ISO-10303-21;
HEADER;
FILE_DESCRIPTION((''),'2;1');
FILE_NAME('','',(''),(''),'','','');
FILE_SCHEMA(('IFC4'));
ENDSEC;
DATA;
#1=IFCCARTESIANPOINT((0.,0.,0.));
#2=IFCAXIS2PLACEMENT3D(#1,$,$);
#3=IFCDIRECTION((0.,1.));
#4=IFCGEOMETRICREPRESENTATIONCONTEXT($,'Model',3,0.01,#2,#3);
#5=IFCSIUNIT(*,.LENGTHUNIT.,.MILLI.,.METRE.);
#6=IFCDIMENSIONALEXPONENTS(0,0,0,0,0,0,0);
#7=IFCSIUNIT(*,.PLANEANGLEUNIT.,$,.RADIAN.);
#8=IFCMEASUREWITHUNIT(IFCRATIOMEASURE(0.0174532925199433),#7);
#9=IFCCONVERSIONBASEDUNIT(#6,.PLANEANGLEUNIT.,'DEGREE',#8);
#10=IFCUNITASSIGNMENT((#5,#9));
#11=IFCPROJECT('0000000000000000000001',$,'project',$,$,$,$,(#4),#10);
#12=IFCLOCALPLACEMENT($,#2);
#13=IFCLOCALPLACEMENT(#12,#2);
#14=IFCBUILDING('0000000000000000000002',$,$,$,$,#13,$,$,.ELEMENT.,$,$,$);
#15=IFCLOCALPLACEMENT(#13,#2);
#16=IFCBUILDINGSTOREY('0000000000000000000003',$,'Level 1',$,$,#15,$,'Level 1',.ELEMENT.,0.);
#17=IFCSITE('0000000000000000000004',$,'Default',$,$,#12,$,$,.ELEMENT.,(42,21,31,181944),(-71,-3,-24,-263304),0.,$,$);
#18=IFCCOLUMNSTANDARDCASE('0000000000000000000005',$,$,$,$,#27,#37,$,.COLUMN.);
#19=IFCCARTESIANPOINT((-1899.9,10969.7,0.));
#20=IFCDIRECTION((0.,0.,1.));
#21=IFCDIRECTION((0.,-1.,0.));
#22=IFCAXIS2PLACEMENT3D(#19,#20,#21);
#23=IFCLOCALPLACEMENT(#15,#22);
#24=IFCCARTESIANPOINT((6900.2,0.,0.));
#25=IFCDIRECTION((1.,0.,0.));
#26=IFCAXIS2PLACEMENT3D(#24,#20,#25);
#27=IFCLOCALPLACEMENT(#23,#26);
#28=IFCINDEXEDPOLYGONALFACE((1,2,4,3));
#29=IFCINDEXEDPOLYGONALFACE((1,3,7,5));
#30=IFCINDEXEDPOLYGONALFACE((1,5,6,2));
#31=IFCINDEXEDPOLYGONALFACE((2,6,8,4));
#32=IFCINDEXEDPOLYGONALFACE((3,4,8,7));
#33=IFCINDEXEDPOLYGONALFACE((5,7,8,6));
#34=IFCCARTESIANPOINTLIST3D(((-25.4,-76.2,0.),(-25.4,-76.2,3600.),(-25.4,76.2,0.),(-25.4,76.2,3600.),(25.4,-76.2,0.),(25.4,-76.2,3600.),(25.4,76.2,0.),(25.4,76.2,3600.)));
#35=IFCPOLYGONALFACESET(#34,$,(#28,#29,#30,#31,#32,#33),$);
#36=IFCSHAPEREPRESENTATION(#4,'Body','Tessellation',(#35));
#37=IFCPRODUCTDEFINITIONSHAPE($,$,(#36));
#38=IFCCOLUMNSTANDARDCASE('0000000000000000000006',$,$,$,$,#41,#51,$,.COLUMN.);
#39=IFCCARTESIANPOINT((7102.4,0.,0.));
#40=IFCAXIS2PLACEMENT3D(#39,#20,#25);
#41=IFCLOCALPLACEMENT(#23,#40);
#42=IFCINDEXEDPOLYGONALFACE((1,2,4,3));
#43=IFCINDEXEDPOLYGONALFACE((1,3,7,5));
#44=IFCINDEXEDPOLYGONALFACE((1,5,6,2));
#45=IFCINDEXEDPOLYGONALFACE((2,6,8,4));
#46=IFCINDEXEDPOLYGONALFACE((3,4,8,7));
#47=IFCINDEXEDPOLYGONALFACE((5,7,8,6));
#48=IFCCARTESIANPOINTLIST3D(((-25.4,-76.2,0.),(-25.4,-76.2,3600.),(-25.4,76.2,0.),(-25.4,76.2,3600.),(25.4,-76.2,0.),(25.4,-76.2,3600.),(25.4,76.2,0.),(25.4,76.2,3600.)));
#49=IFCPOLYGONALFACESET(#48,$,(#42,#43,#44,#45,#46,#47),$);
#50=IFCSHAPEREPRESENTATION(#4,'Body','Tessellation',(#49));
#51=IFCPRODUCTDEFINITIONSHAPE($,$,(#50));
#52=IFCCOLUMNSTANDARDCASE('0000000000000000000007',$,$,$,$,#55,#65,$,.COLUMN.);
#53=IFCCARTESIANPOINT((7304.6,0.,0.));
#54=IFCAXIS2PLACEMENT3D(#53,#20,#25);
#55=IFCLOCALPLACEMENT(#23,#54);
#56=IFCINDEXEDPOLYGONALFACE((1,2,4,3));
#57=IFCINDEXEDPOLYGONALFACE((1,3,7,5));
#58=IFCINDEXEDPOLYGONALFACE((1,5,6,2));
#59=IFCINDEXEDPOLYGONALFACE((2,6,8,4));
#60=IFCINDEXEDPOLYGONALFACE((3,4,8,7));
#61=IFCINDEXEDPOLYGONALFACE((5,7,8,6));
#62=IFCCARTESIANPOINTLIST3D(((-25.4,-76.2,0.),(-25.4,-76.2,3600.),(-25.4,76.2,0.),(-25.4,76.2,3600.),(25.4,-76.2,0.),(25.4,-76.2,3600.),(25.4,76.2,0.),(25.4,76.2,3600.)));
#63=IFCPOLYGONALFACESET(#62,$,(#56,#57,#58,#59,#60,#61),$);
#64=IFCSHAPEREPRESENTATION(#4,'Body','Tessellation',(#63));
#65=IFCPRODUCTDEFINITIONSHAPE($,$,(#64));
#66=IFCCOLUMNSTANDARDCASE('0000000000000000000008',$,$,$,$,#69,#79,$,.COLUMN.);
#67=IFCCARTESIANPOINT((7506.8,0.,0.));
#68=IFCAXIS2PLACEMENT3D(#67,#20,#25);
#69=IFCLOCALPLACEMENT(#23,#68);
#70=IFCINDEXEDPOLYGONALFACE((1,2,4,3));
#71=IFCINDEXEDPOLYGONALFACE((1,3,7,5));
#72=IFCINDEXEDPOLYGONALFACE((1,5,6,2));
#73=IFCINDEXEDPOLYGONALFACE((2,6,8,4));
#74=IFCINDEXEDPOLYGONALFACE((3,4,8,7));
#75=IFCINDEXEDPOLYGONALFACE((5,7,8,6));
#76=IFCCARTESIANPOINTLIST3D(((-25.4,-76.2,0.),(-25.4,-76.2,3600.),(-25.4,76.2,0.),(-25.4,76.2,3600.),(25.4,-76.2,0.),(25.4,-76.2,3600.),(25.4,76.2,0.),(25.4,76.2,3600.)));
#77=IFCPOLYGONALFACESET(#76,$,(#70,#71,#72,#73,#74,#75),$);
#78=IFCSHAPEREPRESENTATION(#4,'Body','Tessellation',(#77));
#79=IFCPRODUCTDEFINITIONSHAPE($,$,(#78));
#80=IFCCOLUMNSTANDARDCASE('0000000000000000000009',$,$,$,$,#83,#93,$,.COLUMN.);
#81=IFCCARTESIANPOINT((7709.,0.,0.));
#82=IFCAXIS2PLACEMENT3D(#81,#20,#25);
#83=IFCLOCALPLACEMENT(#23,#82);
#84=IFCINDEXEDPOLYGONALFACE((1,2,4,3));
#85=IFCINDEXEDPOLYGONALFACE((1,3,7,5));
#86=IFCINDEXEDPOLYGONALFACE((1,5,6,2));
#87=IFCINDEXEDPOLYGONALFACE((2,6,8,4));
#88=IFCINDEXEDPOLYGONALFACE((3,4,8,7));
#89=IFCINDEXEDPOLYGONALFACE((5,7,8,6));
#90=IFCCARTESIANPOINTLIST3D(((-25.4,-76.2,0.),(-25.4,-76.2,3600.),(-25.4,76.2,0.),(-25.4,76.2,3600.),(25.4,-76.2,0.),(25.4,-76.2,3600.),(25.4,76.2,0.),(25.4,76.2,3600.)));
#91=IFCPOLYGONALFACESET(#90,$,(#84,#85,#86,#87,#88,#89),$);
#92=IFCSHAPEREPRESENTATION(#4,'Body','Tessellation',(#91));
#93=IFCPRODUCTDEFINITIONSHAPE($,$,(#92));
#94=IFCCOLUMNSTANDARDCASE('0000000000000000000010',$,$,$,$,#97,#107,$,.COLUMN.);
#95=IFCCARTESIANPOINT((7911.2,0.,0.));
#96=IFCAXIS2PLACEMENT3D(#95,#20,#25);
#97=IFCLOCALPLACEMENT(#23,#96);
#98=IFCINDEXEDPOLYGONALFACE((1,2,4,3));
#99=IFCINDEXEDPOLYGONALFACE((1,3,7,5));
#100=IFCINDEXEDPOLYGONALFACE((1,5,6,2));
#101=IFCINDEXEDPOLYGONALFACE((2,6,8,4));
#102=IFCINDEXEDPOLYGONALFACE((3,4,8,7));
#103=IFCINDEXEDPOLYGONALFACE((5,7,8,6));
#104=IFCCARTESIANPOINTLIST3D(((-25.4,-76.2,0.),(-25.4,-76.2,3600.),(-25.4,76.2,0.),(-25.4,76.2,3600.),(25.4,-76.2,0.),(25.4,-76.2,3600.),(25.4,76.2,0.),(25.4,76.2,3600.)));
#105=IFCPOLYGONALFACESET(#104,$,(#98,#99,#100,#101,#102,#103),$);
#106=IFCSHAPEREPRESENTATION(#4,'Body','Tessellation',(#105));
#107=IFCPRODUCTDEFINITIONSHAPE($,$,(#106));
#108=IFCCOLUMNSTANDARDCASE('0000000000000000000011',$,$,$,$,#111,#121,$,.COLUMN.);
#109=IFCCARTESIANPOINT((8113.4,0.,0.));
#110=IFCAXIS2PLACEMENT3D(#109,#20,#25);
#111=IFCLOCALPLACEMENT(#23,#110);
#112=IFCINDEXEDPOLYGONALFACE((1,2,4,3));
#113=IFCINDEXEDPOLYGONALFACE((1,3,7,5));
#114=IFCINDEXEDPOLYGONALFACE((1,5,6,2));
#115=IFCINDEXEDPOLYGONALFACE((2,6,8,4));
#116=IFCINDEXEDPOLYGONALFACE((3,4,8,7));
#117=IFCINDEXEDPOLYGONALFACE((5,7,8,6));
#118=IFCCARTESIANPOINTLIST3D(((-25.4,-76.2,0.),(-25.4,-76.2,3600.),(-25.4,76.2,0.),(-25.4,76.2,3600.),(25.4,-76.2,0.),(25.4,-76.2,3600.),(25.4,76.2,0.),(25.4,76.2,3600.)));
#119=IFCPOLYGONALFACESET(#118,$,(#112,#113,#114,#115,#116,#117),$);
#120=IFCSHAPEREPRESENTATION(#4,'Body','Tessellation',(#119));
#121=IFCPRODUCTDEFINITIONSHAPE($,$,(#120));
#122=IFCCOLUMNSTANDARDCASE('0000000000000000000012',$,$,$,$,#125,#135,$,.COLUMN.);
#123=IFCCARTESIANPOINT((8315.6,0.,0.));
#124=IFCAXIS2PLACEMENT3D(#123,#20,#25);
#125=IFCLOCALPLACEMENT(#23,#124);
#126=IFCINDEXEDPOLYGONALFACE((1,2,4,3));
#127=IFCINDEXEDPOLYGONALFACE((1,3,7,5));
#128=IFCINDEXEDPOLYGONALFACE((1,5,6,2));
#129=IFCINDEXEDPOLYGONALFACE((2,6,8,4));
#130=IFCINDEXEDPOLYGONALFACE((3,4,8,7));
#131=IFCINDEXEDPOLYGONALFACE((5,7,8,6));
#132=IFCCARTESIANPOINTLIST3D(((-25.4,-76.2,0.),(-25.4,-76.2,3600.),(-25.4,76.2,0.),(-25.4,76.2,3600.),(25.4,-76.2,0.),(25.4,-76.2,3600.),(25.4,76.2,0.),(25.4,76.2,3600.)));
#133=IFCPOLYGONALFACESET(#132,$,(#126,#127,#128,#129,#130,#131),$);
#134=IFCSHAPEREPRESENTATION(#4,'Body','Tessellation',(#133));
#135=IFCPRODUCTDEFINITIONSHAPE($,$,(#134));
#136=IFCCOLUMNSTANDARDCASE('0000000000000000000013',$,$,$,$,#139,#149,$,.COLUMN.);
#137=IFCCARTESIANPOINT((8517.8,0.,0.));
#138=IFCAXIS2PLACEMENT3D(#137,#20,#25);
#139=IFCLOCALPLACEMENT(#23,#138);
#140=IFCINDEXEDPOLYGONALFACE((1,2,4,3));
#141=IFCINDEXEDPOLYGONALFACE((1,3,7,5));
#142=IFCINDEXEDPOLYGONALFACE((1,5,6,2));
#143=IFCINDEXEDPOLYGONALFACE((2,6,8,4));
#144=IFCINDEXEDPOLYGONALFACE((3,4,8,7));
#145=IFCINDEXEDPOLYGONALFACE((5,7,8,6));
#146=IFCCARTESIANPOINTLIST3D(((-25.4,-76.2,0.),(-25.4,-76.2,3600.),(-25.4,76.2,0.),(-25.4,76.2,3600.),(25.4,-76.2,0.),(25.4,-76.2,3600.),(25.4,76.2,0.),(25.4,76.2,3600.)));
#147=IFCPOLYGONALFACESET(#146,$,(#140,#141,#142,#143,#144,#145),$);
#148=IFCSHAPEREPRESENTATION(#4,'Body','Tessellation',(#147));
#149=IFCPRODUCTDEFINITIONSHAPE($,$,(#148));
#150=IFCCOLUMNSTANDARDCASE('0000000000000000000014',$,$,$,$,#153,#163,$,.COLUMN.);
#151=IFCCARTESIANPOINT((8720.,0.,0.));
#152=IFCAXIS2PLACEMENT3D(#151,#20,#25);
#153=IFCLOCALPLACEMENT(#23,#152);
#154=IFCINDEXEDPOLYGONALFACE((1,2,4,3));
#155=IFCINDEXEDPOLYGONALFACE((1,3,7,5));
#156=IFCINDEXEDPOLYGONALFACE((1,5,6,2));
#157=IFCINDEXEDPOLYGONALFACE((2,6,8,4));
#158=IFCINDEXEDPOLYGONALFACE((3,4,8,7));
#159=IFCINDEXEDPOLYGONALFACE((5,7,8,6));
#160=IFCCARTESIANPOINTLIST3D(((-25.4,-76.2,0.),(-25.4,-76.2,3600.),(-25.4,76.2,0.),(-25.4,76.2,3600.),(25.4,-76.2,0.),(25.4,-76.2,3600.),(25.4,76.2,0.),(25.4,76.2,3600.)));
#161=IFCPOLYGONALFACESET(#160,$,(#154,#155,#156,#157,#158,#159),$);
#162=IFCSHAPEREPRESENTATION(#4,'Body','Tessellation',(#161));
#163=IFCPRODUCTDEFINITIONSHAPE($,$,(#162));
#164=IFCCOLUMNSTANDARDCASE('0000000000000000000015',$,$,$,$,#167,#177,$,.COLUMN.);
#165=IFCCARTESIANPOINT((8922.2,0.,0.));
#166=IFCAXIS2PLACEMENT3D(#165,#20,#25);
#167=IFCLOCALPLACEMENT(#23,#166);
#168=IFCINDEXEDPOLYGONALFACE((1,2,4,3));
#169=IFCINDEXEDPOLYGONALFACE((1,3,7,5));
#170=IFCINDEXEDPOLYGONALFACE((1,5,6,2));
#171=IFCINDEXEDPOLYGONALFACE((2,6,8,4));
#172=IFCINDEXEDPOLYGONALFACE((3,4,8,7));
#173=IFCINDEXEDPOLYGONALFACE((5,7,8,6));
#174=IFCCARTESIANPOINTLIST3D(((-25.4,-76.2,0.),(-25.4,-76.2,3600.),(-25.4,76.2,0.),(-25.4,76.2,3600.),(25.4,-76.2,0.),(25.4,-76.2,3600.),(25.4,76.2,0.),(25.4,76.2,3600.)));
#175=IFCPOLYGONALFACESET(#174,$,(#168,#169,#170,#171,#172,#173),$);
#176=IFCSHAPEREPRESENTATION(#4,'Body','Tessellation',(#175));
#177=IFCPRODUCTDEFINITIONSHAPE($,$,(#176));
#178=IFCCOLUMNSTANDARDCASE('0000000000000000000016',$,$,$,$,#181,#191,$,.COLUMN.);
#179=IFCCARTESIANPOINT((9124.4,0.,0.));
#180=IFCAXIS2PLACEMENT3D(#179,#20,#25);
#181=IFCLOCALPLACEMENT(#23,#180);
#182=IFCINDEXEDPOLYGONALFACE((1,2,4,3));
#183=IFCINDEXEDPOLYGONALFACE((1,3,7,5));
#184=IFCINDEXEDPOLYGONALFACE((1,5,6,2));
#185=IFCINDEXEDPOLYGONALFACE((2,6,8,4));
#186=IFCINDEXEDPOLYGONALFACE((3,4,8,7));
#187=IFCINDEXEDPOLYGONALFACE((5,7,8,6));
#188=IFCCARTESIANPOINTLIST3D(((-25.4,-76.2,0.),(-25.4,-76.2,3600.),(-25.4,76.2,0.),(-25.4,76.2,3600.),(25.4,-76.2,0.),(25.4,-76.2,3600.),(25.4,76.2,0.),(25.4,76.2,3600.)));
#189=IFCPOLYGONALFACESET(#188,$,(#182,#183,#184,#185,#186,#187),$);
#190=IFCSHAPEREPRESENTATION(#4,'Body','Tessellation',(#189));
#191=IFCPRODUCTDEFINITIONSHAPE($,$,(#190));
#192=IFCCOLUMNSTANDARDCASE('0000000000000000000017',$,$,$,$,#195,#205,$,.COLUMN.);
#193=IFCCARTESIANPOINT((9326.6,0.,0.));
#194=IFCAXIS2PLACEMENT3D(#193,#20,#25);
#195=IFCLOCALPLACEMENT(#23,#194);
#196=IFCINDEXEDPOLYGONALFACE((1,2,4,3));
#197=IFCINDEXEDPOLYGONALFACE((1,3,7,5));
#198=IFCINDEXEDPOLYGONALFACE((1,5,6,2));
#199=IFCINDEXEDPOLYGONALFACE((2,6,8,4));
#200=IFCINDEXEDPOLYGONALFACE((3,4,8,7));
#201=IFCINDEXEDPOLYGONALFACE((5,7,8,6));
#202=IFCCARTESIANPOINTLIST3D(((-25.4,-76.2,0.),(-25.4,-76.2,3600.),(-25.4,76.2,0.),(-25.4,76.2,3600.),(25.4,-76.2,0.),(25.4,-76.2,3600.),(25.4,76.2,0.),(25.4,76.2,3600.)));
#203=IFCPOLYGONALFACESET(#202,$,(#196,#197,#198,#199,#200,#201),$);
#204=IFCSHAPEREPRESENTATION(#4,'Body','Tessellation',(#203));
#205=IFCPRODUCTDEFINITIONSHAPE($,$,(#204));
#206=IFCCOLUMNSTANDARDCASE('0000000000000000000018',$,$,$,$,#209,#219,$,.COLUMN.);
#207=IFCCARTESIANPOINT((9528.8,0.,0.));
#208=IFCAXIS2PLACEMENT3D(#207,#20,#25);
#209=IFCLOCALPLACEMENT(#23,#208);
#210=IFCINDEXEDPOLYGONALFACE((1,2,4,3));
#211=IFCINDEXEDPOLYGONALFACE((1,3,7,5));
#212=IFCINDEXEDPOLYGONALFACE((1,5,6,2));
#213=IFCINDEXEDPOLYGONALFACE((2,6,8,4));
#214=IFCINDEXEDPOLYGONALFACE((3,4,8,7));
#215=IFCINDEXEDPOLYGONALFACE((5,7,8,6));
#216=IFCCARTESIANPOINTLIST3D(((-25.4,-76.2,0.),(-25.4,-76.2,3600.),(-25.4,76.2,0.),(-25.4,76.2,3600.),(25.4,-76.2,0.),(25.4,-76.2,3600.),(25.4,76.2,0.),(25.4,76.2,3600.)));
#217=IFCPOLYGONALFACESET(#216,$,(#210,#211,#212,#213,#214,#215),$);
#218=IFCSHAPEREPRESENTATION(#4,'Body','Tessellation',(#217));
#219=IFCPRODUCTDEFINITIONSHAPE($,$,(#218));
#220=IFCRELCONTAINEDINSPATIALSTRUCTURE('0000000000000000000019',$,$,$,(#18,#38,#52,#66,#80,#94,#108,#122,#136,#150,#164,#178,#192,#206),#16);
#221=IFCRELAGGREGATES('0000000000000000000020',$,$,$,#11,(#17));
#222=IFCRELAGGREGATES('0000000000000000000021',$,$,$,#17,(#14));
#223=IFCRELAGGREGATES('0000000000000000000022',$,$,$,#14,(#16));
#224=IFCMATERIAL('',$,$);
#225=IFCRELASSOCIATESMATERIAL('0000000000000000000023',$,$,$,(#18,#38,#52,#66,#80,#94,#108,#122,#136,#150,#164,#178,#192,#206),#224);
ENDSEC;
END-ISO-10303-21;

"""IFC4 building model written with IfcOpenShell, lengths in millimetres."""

from ifc_helpers import new_model, entity, si_unit, converted_unit, direction, frame, origin, place, context, project, spatial, rectangle, extrude, material, element, save


model = new_model("IFC4")

# Units and contexts
model_context = context("Model", 3, precision=0.01, world=origin(), true_north=direction((0.0, 1.0)))
ifc_project = project(units=[si_unit("LENGTHUNIT", "METRE", prefix="MILLI"), converted_unit("PLANEANGLEUNIT", "DEGREE", entity("IfcRatioMeasure", 0.0174532925199433), si_unit("PLANEANGLEUNIT", "RADIAN"), dimensions=[0, 0, 0, 0, 0, 0, 0])], contexts=[model_context])

# Site, building, storey
site_placement = place(None, origin())
site = spatial("IfcSite", under=ifc_project, at=site_placement, Name="Default", CompositionType="ELEMENT", RefLatitude=(42, 21, 31, 181944), RefLongitude=(-71, -3, -24, -263304), RefElevation=0.0)
building_placement = place(site_placement, origin())
building = spatial("IfcBuilding", under=site, at=building_placement, CompositionType="ELEMENT")
storey_placement = place(building_placement, origin())
storey = spatial("IfcBuildingStorey", under=building, at=storey_placement, Name="Level 1", LongName="Level 1", CompositionType="ELEMENT", Elevation=0.0)

# Columns
ifc_material_1 = material(Name="")
placement_1 = place(storey_placement, frame((-1899.9, 10969.7, 0.0), z_axis=(0.0, 0.0, 1.0), x_axis=(0.0, -1.0, 0.0)))
for number, where, z_axis, x_axis in (
    (1, (6900.2, 0.0, 0.0), (0.0, 0.0, 1.0), (1.0, 0.0, 0.0)),
    (2, (7102.4, 0.0, 0.0), (0.0, 0.0, 1.0), (1.0, 0.0, 0.0)),
    (3, (7304.6, 0.0, 0.0), (0.0, 0.0, 1.0), (1.0, 0.0, 0.0)),
    (4, (7506.8, 0.0, 0.0), (0.0, 0.0, 1.0), (1.0, 0.0, 0.0)),
    (5, (7709.0, 0.0, 0.0), (0.0, 0.0, 1.0), (1.0, 0.0, 0.0)),
    (6, (7911.2, 0.0, 0.0), (0.0, 0.0, 1.0), (1.0, 0.0, 0.0)),
    (7, (8113.4, 0.0, 0.0), (0.0, 0.0, 1.0), (1.0, 0.0, 0.0)),
    (8, (8315.6, 0.0, 0.0), (0.0, 0.0, 1.0), (1.0, 0.0, 0.0)),
    (9, (8517.8, 0.0, 0.0), (0.0, 0.0, 1.0), (1.0, 0.0, 0.0)),
    (10, (8720.0, 0.0, 0.0), (0.0, 0.0, 1.0), (1.0, 0.0, 0.0)),
    (11, (8922.2, 0.0, 0.0), (0.0, 0.0, 1.0), (1.0, 0.0, 0.0)),
    (12, (9124.4, 0.0, 0.0), (0.0, 0.0, 1.0), (1.0, 0.0, 0.0)),
    (13, (9326.6, 0.0, 0.0), (0.0, 0.0, 1.0), (1.0, 0.0, 0.0)),
    (14, (9528.8, 0.0, 0.0), (0.0, 0.0, 1.0), (1.0, 0.0, 0.0)),
):
    element("IfcColumnStandardCase", number, at=place(placement_1, frame(where, z_axis=z_axis, x_axis=x_axis)), inside=storey, material=ifc_material_1, PredefinedType="COLUMN", context=model_context, shape_type="SweptSolid", body=[
        extrude(rectangle(XDim=50.8, YDim=152.4), origin(), (0.0, 0.0, 1.0), 3600.0),
    ])

save(model, "model.ifc")
